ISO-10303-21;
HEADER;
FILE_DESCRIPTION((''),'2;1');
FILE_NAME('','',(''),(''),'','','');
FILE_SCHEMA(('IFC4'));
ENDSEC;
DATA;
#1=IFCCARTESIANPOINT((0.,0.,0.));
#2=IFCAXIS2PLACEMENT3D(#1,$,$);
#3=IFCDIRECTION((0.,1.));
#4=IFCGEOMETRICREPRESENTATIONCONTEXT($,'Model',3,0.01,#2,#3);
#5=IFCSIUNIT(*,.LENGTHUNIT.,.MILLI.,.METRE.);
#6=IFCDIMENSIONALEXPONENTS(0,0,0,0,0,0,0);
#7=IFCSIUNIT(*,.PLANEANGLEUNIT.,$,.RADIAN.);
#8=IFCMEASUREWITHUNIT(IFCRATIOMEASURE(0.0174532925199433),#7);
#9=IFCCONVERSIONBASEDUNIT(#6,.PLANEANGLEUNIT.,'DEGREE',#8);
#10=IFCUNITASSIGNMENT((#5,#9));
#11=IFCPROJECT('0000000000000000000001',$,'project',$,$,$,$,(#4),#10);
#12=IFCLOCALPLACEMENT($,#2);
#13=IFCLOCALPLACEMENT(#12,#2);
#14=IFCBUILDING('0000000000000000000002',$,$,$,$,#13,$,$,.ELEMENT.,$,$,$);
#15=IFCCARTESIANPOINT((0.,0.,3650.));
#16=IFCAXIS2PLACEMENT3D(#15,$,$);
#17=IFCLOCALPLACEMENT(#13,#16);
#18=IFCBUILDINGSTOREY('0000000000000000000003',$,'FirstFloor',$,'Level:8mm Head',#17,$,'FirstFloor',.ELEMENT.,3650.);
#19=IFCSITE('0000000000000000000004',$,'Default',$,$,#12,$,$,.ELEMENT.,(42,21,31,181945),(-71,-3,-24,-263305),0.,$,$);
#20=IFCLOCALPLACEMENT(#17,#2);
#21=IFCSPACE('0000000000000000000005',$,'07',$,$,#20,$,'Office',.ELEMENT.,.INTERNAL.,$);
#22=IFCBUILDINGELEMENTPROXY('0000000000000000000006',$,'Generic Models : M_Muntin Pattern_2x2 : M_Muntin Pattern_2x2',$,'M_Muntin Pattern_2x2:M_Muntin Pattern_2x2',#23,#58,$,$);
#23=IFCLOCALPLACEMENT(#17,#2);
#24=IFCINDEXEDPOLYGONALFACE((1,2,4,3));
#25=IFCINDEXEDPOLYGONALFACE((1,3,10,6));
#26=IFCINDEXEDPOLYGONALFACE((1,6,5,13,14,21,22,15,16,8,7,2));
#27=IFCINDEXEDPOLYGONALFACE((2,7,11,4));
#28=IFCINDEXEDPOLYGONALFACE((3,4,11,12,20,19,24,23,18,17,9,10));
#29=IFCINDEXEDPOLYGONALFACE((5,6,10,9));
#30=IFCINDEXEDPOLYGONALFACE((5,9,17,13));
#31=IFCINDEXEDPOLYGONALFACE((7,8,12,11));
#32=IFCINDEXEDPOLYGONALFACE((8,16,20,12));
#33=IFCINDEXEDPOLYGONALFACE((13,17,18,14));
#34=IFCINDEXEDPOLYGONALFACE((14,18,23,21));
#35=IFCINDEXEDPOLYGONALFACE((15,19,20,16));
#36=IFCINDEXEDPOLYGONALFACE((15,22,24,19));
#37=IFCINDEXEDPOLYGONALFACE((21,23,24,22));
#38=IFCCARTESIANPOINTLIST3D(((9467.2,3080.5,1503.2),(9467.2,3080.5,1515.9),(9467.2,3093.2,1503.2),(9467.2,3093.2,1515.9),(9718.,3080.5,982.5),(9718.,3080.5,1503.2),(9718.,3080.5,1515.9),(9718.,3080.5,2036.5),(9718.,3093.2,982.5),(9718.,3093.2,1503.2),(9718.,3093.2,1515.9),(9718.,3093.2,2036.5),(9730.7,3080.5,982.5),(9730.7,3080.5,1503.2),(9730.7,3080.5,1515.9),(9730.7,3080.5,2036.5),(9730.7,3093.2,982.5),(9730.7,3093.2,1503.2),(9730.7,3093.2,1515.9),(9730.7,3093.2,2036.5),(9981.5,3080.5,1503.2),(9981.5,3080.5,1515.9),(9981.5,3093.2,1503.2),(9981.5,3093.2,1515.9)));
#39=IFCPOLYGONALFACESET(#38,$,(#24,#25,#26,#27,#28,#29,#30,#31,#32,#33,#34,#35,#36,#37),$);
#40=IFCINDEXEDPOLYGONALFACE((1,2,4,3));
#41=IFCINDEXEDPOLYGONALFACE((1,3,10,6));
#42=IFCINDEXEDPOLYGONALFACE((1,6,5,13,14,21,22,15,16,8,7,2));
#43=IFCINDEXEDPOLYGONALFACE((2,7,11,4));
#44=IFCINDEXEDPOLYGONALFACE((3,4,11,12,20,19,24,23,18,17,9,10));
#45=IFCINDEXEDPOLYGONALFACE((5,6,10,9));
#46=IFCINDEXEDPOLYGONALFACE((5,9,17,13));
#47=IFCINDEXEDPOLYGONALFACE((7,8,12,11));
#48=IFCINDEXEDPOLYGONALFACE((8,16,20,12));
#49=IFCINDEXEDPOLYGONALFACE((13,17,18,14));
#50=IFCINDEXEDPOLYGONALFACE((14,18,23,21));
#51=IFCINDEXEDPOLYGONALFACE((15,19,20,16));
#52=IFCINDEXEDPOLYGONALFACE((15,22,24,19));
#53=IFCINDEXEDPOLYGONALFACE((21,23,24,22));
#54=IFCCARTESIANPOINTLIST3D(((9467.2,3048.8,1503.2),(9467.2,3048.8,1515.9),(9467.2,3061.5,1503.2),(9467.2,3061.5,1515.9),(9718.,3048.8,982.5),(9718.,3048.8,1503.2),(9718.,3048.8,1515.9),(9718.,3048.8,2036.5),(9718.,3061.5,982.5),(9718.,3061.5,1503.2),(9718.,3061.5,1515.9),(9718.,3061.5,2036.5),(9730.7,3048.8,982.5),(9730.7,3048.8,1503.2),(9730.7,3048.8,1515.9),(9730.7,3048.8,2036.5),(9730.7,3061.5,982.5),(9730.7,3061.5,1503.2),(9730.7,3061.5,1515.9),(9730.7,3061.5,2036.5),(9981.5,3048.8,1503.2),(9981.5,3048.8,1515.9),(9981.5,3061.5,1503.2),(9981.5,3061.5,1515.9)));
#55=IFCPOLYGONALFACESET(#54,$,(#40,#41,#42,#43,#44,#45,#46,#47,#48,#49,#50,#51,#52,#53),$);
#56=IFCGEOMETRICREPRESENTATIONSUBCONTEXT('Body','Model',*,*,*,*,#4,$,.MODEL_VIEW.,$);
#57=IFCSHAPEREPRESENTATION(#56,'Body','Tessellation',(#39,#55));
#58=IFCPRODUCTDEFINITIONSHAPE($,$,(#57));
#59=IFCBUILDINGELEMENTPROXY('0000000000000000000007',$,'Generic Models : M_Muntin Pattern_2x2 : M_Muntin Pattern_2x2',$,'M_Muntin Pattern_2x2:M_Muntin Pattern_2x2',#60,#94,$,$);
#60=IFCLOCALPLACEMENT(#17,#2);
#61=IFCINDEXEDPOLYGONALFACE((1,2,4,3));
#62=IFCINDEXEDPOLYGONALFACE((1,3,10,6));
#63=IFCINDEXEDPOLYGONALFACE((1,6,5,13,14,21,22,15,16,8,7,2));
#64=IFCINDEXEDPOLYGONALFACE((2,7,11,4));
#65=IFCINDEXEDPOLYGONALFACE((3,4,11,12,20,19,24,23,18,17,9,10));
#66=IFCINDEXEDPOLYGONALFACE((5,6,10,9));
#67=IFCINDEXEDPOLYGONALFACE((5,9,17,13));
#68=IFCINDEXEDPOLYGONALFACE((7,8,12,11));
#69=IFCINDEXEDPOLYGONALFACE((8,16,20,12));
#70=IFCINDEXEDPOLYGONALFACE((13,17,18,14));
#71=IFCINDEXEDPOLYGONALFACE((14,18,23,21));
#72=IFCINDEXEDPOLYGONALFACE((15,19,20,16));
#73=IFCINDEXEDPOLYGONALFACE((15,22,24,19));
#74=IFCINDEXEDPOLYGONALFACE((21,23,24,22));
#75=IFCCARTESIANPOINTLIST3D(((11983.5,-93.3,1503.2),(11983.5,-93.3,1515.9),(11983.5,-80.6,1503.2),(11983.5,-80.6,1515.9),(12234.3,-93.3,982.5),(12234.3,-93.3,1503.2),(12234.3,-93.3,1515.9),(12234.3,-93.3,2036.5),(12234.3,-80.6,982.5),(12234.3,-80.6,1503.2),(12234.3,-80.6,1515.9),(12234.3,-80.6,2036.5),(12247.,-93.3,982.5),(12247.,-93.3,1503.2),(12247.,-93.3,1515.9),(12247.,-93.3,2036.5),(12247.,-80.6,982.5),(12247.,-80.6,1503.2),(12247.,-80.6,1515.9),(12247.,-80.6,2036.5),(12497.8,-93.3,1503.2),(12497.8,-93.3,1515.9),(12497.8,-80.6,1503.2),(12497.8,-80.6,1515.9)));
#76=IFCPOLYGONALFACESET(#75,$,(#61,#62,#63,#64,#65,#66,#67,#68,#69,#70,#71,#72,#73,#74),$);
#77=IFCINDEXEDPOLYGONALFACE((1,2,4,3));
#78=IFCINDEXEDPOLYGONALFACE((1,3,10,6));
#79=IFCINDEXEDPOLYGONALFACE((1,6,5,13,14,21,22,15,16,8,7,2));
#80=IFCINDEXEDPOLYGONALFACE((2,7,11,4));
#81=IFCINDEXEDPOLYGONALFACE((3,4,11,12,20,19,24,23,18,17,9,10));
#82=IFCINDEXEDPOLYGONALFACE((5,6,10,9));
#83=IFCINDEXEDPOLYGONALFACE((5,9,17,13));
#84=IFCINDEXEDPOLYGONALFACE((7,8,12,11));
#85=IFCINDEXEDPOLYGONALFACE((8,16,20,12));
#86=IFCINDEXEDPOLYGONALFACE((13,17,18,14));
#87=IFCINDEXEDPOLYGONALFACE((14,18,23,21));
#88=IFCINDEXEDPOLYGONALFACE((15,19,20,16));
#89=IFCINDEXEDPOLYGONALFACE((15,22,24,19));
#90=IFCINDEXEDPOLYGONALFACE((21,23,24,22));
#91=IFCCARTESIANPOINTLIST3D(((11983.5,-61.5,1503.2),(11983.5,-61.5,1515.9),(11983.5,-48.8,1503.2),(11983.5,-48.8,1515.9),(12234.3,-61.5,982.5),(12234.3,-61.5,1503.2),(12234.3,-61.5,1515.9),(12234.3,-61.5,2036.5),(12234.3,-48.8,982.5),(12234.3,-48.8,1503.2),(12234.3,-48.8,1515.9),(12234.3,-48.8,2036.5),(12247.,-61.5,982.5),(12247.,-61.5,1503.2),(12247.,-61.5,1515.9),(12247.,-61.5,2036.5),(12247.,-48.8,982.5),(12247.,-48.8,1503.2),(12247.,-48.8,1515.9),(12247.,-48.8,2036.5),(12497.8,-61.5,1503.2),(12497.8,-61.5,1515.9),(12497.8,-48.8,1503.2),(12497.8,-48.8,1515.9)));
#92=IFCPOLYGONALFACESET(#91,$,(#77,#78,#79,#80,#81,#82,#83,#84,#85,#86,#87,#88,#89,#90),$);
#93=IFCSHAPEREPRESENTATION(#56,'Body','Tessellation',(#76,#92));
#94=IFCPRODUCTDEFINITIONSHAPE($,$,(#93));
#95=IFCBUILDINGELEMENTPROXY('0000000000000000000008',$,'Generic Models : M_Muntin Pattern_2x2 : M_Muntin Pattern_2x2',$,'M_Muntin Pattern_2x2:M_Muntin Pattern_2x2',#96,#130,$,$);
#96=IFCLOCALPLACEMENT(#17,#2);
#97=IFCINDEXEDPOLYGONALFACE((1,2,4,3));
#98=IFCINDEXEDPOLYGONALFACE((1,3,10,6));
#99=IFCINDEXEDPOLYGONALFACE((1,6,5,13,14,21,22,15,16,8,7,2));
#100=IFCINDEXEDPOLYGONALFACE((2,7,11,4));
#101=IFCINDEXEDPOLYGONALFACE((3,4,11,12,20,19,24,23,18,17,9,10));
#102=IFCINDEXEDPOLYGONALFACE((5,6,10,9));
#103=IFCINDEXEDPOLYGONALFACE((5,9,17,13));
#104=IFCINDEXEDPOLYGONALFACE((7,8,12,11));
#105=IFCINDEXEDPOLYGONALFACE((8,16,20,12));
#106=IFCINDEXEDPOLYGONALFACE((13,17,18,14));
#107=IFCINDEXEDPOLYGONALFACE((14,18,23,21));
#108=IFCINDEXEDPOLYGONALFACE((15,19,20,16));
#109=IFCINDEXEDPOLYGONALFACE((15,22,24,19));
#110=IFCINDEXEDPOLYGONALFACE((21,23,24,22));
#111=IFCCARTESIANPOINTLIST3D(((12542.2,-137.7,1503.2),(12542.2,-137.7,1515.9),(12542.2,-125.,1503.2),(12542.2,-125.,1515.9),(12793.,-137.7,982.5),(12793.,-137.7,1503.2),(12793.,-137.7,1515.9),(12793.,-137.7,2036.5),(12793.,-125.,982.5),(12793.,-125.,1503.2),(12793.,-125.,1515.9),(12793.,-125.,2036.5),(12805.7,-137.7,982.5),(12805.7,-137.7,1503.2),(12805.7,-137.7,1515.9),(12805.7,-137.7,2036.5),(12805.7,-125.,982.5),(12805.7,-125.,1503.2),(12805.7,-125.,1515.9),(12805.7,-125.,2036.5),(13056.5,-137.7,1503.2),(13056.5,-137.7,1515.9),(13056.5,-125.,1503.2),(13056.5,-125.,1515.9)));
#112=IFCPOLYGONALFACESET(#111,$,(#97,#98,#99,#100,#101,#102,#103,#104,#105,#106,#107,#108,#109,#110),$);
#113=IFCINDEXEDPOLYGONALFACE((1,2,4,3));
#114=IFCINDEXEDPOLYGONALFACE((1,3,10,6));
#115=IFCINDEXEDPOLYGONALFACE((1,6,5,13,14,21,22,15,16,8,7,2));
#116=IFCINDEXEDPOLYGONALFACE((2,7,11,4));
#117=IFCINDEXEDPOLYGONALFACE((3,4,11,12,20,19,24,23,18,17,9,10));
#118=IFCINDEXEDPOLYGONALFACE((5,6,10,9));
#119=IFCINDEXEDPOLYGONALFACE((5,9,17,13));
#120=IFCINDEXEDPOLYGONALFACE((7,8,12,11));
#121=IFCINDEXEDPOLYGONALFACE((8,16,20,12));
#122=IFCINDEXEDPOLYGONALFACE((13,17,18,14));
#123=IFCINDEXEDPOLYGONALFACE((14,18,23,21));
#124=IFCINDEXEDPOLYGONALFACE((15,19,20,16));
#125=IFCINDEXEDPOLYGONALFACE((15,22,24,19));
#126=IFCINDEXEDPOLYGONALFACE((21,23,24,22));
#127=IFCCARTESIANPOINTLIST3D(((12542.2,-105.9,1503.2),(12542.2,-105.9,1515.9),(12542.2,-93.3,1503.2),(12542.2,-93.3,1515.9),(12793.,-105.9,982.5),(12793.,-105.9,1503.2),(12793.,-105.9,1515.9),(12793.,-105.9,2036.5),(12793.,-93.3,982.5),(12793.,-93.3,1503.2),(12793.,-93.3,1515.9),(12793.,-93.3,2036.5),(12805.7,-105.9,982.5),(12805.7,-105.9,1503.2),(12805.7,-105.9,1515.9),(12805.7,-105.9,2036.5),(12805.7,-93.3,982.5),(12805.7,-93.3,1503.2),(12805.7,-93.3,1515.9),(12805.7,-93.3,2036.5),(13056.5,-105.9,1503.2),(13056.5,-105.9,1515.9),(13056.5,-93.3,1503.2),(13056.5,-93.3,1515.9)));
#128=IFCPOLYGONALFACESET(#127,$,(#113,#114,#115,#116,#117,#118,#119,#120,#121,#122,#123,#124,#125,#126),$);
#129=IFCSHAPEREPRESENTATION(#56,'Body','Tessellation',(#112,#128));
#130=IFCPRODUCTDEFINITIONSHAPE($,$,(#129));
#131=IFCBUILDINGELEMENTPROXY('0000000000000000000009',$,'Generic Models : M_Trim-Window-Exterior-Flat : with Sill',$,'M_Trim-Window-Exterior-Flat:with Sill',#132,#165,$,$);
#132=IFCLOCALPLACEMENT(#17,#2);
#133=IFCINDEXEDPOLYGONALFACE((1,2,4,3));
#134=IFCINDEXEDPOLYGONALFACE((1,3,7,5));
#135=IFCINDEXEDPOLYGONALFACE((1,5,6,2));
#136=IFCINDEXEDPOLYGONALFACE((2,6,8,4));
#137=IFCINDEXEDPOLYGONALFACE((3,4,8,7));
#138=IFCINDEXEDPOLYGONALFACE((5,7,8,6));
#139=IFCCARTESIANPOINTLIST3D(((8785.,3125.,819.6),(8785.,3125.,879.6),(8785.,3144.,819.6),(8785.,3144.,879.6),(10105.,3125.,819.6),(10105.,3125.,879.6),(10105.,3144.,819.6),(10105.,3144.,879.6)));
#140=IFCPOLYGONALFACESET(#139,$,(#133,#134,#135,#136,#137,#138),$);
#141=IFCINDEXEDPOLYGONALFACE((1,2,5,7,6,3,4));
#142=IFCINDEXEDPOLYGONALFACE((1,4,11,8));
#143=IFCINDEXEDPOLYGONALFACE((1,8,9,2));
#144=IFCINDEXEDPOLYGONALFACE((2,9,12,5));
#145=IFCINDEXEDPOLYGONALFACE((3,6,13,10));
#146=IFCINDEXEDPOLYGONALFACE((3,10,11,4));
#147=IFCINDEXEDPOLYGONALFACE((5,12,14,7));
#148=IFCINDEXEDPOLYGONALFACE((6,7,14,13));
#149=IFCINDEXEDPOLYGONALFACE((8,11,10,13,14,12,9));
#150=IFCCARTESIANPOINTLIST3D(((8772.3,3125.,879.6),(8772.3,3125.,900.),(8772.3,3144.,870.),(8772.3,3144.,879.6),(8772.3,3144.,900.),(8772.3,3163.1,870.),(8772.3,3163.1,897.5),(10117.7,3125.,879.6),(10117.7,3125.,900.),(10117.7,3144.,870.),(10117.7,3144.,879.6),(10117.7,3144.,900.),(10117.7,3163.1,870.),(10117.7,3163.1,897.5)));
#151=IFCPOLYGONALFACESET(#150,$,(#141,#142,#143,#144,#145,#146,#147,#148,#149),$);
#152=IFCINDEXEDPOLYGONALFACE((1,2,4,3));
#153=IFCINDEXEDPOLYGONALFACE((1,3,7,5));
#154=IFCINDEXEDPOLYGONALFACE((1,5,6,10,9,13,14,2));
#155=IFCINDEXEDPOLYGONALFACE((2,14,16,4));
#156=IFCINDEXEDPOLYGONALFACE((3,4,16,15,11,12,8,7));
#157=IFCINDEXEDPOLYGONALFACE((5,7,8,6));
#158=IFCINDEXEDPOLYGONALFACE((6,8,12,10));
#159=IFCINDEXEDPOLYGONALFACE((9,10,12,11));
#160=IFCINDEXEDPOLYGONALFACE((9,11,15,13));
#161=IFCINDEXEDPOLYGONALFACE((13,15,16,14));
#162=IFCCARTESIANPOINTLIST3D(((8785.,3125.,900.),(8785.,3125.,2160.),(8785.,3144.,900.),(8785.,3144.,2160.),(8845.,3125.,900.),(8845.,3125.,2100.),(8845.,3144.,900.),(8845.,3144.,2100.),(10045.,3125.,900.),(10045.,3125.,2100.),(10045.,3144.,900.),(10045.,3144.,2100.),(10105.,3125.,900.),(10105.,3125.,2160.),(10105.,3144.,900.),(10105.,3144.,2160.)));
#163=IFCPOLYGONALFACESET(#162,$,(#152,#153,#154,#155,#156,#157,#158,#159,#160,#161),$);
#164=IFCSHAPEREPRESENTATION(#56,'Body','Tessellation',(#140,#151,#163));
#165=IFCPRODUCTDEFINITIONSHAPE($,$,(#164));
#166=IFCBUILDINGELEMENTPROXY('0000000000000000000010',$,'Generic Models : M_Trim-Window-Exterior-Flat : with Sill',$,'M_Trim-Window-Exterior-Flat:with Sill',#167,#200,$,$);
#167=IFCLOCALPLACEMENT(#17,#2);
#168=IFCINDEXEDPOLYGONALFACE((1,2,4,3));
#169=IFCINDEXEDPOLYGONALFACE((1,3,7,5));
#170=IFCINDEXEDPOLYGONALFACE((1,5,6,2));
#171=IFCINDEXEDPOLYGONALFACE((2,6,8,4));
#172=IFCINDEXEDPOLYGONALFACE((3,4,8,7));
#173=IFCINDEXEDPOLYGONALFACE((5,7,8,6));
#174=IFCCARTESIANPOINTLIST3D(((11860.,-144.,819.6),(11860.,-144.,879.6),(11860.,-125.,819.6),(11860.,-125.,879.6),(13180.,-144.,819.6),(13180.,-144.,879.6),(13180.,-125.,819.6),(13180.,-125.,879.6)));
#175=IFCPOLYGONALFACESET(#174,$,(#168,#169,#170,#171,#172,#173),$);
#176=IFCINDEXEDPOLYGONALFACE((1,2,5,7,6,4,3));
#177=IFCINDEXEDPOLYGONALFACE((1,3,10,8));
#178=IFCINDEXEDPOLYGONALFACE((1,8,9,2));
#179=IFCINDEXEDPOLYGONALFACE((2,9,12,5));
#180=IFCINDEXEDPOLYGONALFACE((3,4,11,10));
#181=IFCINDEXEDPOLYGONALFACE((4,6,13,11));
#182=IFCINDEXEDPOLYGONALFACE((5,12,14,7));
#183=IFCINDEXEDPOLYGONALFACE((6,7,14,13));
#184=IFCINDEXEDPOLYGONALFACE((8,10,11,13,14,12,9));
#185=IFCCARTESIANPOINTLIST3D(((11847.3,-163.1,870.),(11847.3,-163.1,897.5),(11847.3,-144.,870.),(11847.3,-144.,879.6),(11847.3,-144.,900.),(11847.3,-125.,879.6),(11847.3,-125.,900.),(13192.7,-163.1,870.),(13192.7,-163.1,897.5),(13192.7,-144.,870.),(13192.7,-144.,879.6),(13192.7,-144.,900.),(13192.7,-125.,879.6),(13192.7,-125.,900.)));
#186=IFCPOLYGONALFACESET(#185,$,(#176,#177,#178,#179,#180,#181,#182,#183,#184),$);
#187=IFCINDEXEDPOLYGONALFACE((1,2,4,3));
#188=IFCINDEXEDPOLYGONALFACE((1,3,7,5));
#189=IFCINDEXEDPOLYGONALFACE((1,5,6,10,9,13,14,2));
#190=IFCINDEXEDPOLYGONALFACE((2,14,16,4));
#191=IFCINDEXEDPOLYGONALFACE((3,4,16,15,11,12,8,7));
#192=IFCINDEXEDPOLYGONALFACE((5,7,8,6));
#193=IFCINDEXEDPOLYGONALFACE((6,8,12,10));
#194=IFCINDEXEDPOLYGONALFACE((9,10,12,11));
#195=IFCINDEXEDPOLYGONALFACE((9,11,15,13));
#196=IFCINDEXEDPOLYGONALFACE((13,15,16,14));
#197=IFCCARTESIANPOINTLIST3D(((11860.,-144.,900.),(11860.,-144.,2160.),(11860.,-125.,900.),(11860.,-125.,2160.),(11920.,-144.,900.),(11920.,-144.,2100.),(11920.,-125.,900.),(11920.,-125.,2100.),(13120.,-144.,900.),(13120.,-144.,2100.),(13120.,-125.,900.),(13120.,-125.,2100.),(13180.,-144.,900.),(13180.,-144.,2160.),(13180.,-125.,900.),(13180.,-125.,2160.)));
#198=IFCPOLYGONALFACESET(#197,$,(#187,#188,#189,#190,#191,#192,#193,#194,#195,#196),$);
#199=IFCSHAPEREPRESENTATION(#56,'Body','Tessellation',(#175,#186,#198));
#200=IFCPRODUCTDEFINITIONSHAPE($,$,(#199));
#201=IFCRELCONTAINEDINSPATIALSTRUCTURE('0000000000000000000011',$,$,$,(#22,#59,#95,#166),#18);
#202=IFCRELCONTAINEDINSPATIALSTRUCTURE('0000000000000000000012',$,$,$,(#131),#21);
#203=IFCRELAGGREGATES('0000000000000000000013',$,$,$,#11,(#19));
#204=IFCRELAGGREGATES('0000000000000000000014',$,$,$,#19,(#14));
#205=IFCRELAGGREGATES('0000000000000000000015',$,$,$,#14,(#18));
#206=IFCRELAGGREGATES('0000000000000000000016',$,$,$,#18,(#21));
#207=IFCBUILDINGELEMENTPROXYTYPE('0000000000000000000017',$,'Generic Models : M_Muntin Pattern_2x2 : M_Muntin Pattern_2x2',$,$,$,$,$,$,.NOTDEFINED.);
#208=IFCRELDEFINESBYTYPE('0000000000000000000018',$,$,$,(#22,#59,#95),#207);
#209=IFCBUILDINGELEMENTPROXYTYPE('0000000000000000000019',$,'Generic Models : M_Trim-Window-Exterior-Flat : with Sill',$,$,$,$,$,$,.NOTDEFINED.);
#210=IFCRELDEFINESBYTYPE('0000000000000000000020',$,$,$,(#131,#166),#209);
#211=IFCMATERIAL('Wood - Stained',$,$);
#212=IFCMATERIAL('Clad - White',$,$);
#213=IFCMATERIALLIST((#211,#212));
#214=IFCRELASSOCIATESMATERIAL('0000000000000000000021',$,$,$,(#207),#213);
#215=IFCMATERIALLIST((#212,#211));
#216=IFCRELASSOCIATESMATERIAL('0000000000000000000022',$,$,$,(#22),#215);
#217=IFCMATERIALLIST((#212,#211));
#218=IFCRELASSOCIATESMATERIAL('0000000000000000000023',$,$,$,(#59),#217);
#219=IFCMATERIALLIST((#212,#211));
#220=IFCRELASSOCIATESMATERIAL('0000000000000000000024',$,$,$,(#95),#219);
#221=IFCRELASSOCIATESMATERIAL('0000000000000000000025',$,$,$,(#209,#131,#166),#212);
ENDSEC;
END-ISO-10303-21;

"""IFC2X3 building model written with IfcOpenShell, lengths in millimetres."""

from ifc_helpers import new_model, entity, si_unit, converted_unit, direction, frame, frame_2d, origin, place, context, subcontext, project, spatial, polyline, rectangle, outline, extrude, source, transform, mapped, material, material_list, type_object, type_shapes, element, save


model = new_model("IFC2X3")

# Units and contexts
model_context = context("Model", 3, precision=0.01, world=origin(), true_north=direction((0.0, 1.0)))
body_context = subcontext(model_context, "Body", "Model", "MODEL_VIEW")
ifc_project = project(units=[si_unit("LENGTHUNIT", "METRE", prefix="MILLI"), converted_unit("PLANEANGLEUNIT", "DEGREE", entity("IfcRatioMeasure", 0.0174532925199433), si_unit("PLANEANGLEUNIT", "RADIAN"), dimensions=[0, 0, 0, 0, 0, 0, 0])], contexts=[model_context])

# Site, building, storey
site_placement = place(None, origin())
site = spatial("IfcSite", under=ifc_project, at=site_placement, Name="Default", CompositionType="ELEMENT", RefLatitude=(42, 21, 31, 181945), RefLongitude=(-71, -3, -24, -263305), RefElevation=0.0)
building_placement = place(site_placement, origin())
building = spatial("IfcBuilding", under=site, at=building_placement, CompositionType="ELEMENT")
storey_placement = place(building_placement, frame((0.0, 0.0, 3650.0)))
storey = spatial("IfcBuildingStorey", under=building, at=storey_placement, Name="FirstFloor", ObjectType="Level:8mm Head", LongName="FirstFloor", CompositionType="ELEMENT", Elevation=3650.0)

# Building element proxies
ifc_material_1 = material(Name="Clad - White")
ifc_material_2 = material(Name="Wood - Stained")
ifc_material_list_1 = material_list([ifc_material_1, ifc_material_2])
ifc_material_list_2 = material_list([ifc_material_2, ifc_material_1])
building_element_proxy_type_1 = type_object("IfcBuildingElementProxyType", Name="Generic Models : M_Muntin Pattern_2x2 : M_Muntin Pattern_2x2", PredefinedType="NOTDEFINED", material=ifc_material_list_2)
shared_shape_1 = source(origin(), body_context, "Body", "SweptSolid", [
    extrude(outline(polyline([(6.4, -6.4), (527.0, -6.4), (527.0, 6.3), (6.4, 6.3), (6.4, 257.1), (-6.3, 257.1), (-6.3, 6.3), (-527.0, 6.3), (-527.0, -6.4), (-6.3, -6.4), (-6.3, -257.1), (6.4, -257.1), (6.4, -6.4)])), frame((0.0, 9.5, 527.0), z_axis=(0.0, 1.0, 0.0), x_axis=(0.0, 0.0, 1.0)), (0.0, 0.0, 1.0), 12.7),
    extrude(outline(polyline([(6.4, -6.4), (527.0, -6.4), (527.0, 6.3), (6.4, 6.3), (6.4, 257.1), (-6.3, 257.1), (-6.3, 6.3), (-527.0, 6.3), (-527.0, -6.4), (-6.3, -6.4), (-6.3, -257.1), (6.4, -257.1), (6.4, -6.4)])), frame((0.0, -22.2, 527.0), z_axis=(0.0, 1.0, 0.0), x_axis=(0.0, 0.0, 1.0)), (0.0, 0.0, 1.0), 12.7),
])
type_shapes(building_element_proxy_type_1, [shared_shape_1])
proxy_1_placement = place(storey_placement, frame((9724.4, 3071.0, 982.5)))
element("IfcBuildingElementProxy", 1, at=proxy_1_placement, inside=storey, type_object=building_element_proxy_type_1, material=ifc_material_list_1, Name="Generic Models : M_Muntin Pattern_2x2 : M_Muntin Pattern_2x2", ObjectType="M_Muntin Pattern_2x2:M_Muntin Pattern_2x2", context=body_context, shape_type="MappedRepresentation", body=[
    mapped(shared_shape_1, transform((0.0, 0.0, 0.0), scale=1.0)),
])
ifc_material_list_3 = material_list([ifc_material_1, ifc_material_2])
proxy_2_placement = place(storey_placement, frame((12240.6, -71.0, 982.5), z_axis=(0.0, 0.0, 1.0), x_axis=(-1.0, 0.0, 0.0)))
element("IfcBuildingElementProxy", 2, at=proxy_2_placement, inside=storey, type_object=building_element_proxy_type_1, material=ifc_material_list_3, Name="Generic Models : M_Muntin Pattern_2x2 : M_Muntin Pattern_2x2", ObjectType="M_Muntin Pattern_2x2:M_Muntin Pattern_2x2", context=body_context, shape_type="MappedRepresentation", body=[
    mapped(shared_shape_1, transform((0.0, 0.0, 0.0), scale=1.0)),
])
ifc_material_list_4 = material_list([ifc_material_1, ifc_material_2])
proxy_3_placement = place(storey_placement, frame((12799.4, -115.5, 982.5), z_axis=(0.0, 0.0, 1.0), x_axis=(-1.0, 0.0, 0.0)))
element("IfcBuildingElementProxy", 3, at=proxy_3_placement, inside=storey, type_object=building_element_proxy_type_1, material=ifc_material_list_4, Name="Generic Models : M_Muntin Pattern_2x2 : M_Muntin Pattern_2x2", ObjectType="M_Muntin Pattern_2x2:M_Muntin Pattern_2x2", context=body_context, shape_type="MappedRepresentation", body=[
    mapped(shared_shape_1, transform((0.0, 0.0, 0.0), scale=1.0)),
])

# Shared definitions
space_placement = place(storey_placement, origin())
space = spatial("IfcSpace", under=storey, at=space_placement, Name="07", LongName="Office", CompositionType="ELEMENT", InteriorOrExteriorSpace="INTERNAL")

# Building element proxies
building_element_proxy_type_2 = type_object("IfcBuildingElementProxyType", Name="Generic Models : M_Trim-Window-Exterior-Flat : with Sill", PredefinedType="NOTDEFINED", material=ifc_material_1)
shared_shape_2 = source(origin(), body_context, "Body", "SweptSolid", [
    extrude(rectangle(XDim=1320.0, YDim=60.0, at=frame_2d((0.0, 0.0), x_axis=(1.0, 0.0))), frame((0.0, -1250.4, 0.0), z_axis=(0.0, 0.0, 1.0), x_axis=(-1.0, 0.0, 0.0)), (0.0, 0.0, 1.0), 19.1),
    extrude(outline(polyline([(-19.0, -15.2), (0.0, -15.2), (0.0, -5.7), (19.0, -5.7), (19.0, 14.8), (0.0, 14.8), (-19.0, 12.3), (-19.0, -15.2)])), frame((-672.7, -1214.8, 19.0), z_axis=(1.0, 0.0, 0.0), x_axis=(0.0, 0.0, -1.0)), (0.0, 0.0, 1.0), 1345.4),
    extrude(outline(polyline([(-645.0, -660.0), (615.0, -660.0), (615.0, -600.0), (-585.0, -600.0), (-585.0, 600.0), (615.0, 600.0), (615.0, 660.0), (-645.0, 660.0), (-645.0, -660.0)])), frame((0.0, -585.0, 0.0), z_axis=(0.0, 0.0, 1.0), x_axis=(0.0, -1.0, 0.0)), (0.0, 0.0, 1.0), 19.1),
])
type_shapes(building_element_proxy_type_2, [shared_shape_2])
proxy_4_placement = place(space_placement, frame((9445.0, 3125.0, 2100.0), z_axis=(0.0, 1.0, 0.0), x_axis=(-1.0, 0.0, 0.0)))
element("IfcBuildingElementProxy", 4, at=proxy_4_placement, inside=space, type_object=building_element_proxy_type_2, material=ifc_material_1, Name="Generic Models : M_Trim-Window-Exterior-Flat : with Sill", ObjectType="M_Trim-Window-Exterior-Flat:with Sill", context=body_context, shape_type="MappedRepresentation", body=[
    mapped(shared_shape_2, transform((0.0, 0.0, 0.0), scale=1.0)),
])
proxy_5_placement = place(storey_placement, frame((12520.0, -125.0, 2100.0), z_axis=(0.0, -1.0, 0.0), x_axis=(1.0, 0.0, 0.0)))
element("IfcBuildingElementProxy", 5, at=proxy_5_placement, inside=storey, type_object=building_element_proxy_type_2, material=ifc_material_1, Name="Generic Models : M_Trim-Window-Exterior-Flat : with Sill", ObjectType="M_Trim-Window-Exterior-Flat:with Sill", context=body_context, shape_type="MappedRepresentation", body=[
    mapped(shared_shape_2, transform((0.0, 0.0, 0.0), scale=1.0)),
])

save(model, "model.ifc")
